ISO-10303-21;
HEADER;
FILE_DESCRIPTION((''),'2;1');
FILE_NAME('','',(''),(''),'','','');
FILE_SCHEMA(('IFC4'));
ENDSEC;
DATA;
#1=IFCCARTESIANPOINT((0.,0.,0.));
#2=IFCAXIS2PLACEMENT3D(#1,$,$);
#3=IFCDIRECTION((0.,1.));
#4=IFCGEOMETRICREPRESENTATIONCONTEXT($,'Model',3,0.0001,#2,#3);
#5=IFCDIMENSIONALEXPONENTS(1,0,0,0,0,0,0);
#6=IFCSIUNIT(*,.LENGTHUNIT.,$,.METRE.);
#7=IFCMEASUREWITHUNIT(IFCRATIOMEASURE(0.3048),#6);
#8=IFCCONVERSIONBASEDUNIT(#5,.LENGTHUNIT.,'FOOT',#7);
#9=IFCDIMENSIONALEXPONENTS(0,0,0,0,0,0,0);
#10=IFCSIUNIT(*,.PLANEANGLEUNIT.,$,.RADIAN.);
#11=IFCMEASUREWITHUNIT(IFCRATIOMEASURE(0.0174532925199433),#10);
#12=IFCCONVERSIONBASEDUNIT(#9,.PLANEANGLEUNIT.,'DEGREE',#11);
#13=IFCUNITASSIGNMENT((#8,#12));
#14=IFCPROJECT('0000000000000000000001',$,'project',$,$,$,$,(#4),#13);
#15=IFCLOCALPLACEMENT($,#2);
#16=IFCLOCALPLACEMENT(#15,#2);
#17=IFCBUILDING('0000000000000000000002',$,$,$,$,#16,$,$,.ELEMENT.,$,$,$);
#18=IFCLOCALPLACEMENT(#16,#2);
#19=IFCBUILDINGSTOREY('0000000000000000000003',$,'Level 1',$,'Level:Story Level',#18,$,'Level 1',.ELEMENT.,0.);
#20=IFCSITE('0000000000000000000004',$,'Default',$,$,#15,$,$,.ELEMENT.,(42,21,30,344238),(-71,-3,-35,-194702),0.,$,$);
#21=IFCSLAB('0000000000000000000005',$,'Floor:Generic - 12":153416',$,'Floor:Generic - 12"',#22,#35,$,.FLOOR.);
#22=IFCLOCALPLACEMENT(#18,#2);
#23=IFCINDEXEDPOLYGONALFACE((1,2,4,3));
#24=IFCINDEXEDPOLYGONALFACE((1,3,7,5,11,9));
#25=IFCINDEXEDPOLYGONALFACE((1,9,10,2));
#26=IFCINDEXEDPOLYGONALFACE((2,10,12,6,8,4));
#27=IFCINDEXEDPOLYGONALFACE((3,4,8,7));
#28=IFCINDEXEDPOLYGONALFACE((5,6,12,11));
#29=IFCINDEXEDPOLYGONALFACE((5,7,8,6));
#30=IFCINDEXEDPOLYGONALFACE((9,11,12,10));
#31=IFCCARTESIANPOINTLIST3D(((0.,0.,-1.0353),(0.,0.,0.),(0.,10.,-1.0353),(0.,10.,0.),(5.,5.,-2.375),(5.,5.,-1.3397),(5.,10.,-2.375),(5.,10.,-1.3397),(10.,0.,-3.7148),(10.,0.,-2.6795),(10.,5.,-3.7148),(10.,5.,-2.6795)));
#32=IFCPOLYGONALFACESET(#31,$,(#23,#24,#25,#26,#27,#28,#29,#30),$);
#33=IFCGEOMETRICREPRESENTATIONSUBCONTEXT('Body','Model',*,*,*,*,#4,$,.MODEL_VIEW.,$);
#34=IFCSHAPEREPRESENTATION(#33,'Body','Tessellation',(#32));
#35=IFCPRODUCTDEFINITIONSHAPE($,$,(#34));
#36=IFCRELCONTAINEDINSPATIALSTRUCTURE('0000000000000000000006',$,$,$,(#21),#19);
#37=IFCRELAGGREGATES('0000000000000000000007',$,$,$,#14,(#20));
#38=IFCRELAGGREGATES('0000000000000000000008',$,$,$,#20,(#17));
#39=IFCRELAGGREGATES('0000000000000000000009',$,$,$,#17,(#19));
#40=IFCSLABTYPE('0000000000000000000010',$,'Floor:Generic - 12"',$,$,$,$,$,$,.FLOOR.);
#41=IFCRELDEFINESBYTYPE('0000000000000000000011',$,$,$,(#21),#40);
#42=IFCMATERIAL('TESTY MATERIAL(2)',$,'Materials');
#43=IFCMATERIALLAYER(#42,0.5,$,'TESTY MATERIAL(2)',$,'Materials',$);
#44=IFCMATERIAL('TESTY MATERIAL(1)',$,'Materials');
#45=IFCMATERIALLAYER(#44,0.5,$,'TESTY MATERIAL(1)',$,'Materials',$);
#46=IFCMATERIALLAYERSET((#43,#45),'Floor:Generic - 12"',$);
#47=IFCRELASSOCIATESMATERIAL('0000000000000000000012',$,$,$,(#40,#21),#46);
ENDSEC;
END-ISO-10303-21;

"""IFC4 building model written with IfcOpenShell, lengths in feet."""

from ifc_helpers import new_model, entity, si_unit, converted_unit, direction, frame, origin, place, context, subcontext, project, spatial, polyline, outline, extrude, clip, halfspace, material, layer, layer_set, layer_usage, type_object, element, save


model = new_model("IFC4")

# Units and contexts
model_context = context("Model", 3, precision=0.0001, world=origin(), true_north=direction((0.0, 1.0)))
body_context = subcontext(model_context, "Body", "Model", "MODEL_VIEW")
ifc_project = project(units=[converted_unit("LENGTHUNIT", "FOOT", entity("IfcRatioMeasure", 0.3048), si_unit("LENGTHUNIT", "METRE"), dimensions=[1, 0, 0, 0, 0, 0, 0]), converted_unit("PLANEANGLEUNIT", "DEGREE", entity("IfcRatioMeasure", 0.0174532925199433), si_unit("PLANEANGLEUNIT", "RADIAN"), dimensions=[0, 0, 0, 0, 0, 0, 0])], contexts=[model_context])

# Site, building, storey
site_placement = place(None, origin())
site = spatial("IfcSite", under=ifc_project, at=site_placement, Name="Default", CompositionType="ELEMENT", RefLatitude=(42, 21, 30, 344238), RefLongitude=(-71, -3, -35, -194702), RefElevation=0.0)
building_placement = place(site_placement, origin())
building = spatial("IfcBuilding", under=site, at=building_placement, CompositionType="ELEMENT")
storey_placement = place(building_placement, origin())
storey = spatial("IfcBuildingStorey", under=building, at=storey_placement, Name="Level 1", ObjectType="Level:Story Level", LongName="Level 1", CompositionType="ELEMENT", Elevation=0.0)

# Slab
ifc_material_1 = material(Name="TESTY MATERIAL(2)", Category="Materials")
ifc_layer_1 = layer(ifc_material_1, 0.5, Name="TESTY MATERIAL(2)", Category="Materials")
ifc_material_2 = material(Name="TESTY MATERIAL(1)", Category="Materials")
ifc_layer_2 = layer(ifc_material_2, 0.5, Name="TESTY MATERIAL(1)", Category="Materials")
ifc_layer_set = layer_set([ifc_layer_1, ifc_layer_2], Name="Floor:Generic - 12\"")
ifc_layer_usage = layer_usage(ifc_layer_set, "AXIS3", "POSITIVE", 0.0)
slab_type = type_object("IfcSlabType", Name="Floor:Generic - 12\"", PredefinedType="FLOOR", material=ifc_layer_set)
slab_placement = place(storey_placement, origin())
element("IfcSlab", 1, at=slab_placement, inside=storey, type_object=slab_type, material=ifc_layer_usage, Name="Floor:Generic - 12\":153416", ObjectType="Floor:Generic - 12\"", PredefinedType="FLOOR", context=body_context, shape_type="Clipping", body=[
    clip(clip(extrude(outline(polyline([(-5.0, -5.1764), (5.0, -5.1764), (5.0, 0.0), (0.0, 0.0), (0.0, 5.1764), (-5.0, 5.1764), (-5.0, -5.1764)])), frame((5.0, 5.0, -1.3397), z_axis=(-0.258819, 0.0, -0.965926), x_axis=(0.0, 1.0, 0.0)), (0.0, 0.258819, 0.965926), 1.0718), halfspace(frame((0.0, 10.0, -1.0353), z_axis=(-0.258819, 0.0, -0.965926), x_axis=(-0.965926, 0.0, 0.258819)), False)), halfspace(frame((0.0, 10.0, 0.0), z_axis=(0.258819, 0.0, 0.965926), x_axis=(0.965926, 0.0, -0.258819)), False)),
])

save(model, "model.ifc")
